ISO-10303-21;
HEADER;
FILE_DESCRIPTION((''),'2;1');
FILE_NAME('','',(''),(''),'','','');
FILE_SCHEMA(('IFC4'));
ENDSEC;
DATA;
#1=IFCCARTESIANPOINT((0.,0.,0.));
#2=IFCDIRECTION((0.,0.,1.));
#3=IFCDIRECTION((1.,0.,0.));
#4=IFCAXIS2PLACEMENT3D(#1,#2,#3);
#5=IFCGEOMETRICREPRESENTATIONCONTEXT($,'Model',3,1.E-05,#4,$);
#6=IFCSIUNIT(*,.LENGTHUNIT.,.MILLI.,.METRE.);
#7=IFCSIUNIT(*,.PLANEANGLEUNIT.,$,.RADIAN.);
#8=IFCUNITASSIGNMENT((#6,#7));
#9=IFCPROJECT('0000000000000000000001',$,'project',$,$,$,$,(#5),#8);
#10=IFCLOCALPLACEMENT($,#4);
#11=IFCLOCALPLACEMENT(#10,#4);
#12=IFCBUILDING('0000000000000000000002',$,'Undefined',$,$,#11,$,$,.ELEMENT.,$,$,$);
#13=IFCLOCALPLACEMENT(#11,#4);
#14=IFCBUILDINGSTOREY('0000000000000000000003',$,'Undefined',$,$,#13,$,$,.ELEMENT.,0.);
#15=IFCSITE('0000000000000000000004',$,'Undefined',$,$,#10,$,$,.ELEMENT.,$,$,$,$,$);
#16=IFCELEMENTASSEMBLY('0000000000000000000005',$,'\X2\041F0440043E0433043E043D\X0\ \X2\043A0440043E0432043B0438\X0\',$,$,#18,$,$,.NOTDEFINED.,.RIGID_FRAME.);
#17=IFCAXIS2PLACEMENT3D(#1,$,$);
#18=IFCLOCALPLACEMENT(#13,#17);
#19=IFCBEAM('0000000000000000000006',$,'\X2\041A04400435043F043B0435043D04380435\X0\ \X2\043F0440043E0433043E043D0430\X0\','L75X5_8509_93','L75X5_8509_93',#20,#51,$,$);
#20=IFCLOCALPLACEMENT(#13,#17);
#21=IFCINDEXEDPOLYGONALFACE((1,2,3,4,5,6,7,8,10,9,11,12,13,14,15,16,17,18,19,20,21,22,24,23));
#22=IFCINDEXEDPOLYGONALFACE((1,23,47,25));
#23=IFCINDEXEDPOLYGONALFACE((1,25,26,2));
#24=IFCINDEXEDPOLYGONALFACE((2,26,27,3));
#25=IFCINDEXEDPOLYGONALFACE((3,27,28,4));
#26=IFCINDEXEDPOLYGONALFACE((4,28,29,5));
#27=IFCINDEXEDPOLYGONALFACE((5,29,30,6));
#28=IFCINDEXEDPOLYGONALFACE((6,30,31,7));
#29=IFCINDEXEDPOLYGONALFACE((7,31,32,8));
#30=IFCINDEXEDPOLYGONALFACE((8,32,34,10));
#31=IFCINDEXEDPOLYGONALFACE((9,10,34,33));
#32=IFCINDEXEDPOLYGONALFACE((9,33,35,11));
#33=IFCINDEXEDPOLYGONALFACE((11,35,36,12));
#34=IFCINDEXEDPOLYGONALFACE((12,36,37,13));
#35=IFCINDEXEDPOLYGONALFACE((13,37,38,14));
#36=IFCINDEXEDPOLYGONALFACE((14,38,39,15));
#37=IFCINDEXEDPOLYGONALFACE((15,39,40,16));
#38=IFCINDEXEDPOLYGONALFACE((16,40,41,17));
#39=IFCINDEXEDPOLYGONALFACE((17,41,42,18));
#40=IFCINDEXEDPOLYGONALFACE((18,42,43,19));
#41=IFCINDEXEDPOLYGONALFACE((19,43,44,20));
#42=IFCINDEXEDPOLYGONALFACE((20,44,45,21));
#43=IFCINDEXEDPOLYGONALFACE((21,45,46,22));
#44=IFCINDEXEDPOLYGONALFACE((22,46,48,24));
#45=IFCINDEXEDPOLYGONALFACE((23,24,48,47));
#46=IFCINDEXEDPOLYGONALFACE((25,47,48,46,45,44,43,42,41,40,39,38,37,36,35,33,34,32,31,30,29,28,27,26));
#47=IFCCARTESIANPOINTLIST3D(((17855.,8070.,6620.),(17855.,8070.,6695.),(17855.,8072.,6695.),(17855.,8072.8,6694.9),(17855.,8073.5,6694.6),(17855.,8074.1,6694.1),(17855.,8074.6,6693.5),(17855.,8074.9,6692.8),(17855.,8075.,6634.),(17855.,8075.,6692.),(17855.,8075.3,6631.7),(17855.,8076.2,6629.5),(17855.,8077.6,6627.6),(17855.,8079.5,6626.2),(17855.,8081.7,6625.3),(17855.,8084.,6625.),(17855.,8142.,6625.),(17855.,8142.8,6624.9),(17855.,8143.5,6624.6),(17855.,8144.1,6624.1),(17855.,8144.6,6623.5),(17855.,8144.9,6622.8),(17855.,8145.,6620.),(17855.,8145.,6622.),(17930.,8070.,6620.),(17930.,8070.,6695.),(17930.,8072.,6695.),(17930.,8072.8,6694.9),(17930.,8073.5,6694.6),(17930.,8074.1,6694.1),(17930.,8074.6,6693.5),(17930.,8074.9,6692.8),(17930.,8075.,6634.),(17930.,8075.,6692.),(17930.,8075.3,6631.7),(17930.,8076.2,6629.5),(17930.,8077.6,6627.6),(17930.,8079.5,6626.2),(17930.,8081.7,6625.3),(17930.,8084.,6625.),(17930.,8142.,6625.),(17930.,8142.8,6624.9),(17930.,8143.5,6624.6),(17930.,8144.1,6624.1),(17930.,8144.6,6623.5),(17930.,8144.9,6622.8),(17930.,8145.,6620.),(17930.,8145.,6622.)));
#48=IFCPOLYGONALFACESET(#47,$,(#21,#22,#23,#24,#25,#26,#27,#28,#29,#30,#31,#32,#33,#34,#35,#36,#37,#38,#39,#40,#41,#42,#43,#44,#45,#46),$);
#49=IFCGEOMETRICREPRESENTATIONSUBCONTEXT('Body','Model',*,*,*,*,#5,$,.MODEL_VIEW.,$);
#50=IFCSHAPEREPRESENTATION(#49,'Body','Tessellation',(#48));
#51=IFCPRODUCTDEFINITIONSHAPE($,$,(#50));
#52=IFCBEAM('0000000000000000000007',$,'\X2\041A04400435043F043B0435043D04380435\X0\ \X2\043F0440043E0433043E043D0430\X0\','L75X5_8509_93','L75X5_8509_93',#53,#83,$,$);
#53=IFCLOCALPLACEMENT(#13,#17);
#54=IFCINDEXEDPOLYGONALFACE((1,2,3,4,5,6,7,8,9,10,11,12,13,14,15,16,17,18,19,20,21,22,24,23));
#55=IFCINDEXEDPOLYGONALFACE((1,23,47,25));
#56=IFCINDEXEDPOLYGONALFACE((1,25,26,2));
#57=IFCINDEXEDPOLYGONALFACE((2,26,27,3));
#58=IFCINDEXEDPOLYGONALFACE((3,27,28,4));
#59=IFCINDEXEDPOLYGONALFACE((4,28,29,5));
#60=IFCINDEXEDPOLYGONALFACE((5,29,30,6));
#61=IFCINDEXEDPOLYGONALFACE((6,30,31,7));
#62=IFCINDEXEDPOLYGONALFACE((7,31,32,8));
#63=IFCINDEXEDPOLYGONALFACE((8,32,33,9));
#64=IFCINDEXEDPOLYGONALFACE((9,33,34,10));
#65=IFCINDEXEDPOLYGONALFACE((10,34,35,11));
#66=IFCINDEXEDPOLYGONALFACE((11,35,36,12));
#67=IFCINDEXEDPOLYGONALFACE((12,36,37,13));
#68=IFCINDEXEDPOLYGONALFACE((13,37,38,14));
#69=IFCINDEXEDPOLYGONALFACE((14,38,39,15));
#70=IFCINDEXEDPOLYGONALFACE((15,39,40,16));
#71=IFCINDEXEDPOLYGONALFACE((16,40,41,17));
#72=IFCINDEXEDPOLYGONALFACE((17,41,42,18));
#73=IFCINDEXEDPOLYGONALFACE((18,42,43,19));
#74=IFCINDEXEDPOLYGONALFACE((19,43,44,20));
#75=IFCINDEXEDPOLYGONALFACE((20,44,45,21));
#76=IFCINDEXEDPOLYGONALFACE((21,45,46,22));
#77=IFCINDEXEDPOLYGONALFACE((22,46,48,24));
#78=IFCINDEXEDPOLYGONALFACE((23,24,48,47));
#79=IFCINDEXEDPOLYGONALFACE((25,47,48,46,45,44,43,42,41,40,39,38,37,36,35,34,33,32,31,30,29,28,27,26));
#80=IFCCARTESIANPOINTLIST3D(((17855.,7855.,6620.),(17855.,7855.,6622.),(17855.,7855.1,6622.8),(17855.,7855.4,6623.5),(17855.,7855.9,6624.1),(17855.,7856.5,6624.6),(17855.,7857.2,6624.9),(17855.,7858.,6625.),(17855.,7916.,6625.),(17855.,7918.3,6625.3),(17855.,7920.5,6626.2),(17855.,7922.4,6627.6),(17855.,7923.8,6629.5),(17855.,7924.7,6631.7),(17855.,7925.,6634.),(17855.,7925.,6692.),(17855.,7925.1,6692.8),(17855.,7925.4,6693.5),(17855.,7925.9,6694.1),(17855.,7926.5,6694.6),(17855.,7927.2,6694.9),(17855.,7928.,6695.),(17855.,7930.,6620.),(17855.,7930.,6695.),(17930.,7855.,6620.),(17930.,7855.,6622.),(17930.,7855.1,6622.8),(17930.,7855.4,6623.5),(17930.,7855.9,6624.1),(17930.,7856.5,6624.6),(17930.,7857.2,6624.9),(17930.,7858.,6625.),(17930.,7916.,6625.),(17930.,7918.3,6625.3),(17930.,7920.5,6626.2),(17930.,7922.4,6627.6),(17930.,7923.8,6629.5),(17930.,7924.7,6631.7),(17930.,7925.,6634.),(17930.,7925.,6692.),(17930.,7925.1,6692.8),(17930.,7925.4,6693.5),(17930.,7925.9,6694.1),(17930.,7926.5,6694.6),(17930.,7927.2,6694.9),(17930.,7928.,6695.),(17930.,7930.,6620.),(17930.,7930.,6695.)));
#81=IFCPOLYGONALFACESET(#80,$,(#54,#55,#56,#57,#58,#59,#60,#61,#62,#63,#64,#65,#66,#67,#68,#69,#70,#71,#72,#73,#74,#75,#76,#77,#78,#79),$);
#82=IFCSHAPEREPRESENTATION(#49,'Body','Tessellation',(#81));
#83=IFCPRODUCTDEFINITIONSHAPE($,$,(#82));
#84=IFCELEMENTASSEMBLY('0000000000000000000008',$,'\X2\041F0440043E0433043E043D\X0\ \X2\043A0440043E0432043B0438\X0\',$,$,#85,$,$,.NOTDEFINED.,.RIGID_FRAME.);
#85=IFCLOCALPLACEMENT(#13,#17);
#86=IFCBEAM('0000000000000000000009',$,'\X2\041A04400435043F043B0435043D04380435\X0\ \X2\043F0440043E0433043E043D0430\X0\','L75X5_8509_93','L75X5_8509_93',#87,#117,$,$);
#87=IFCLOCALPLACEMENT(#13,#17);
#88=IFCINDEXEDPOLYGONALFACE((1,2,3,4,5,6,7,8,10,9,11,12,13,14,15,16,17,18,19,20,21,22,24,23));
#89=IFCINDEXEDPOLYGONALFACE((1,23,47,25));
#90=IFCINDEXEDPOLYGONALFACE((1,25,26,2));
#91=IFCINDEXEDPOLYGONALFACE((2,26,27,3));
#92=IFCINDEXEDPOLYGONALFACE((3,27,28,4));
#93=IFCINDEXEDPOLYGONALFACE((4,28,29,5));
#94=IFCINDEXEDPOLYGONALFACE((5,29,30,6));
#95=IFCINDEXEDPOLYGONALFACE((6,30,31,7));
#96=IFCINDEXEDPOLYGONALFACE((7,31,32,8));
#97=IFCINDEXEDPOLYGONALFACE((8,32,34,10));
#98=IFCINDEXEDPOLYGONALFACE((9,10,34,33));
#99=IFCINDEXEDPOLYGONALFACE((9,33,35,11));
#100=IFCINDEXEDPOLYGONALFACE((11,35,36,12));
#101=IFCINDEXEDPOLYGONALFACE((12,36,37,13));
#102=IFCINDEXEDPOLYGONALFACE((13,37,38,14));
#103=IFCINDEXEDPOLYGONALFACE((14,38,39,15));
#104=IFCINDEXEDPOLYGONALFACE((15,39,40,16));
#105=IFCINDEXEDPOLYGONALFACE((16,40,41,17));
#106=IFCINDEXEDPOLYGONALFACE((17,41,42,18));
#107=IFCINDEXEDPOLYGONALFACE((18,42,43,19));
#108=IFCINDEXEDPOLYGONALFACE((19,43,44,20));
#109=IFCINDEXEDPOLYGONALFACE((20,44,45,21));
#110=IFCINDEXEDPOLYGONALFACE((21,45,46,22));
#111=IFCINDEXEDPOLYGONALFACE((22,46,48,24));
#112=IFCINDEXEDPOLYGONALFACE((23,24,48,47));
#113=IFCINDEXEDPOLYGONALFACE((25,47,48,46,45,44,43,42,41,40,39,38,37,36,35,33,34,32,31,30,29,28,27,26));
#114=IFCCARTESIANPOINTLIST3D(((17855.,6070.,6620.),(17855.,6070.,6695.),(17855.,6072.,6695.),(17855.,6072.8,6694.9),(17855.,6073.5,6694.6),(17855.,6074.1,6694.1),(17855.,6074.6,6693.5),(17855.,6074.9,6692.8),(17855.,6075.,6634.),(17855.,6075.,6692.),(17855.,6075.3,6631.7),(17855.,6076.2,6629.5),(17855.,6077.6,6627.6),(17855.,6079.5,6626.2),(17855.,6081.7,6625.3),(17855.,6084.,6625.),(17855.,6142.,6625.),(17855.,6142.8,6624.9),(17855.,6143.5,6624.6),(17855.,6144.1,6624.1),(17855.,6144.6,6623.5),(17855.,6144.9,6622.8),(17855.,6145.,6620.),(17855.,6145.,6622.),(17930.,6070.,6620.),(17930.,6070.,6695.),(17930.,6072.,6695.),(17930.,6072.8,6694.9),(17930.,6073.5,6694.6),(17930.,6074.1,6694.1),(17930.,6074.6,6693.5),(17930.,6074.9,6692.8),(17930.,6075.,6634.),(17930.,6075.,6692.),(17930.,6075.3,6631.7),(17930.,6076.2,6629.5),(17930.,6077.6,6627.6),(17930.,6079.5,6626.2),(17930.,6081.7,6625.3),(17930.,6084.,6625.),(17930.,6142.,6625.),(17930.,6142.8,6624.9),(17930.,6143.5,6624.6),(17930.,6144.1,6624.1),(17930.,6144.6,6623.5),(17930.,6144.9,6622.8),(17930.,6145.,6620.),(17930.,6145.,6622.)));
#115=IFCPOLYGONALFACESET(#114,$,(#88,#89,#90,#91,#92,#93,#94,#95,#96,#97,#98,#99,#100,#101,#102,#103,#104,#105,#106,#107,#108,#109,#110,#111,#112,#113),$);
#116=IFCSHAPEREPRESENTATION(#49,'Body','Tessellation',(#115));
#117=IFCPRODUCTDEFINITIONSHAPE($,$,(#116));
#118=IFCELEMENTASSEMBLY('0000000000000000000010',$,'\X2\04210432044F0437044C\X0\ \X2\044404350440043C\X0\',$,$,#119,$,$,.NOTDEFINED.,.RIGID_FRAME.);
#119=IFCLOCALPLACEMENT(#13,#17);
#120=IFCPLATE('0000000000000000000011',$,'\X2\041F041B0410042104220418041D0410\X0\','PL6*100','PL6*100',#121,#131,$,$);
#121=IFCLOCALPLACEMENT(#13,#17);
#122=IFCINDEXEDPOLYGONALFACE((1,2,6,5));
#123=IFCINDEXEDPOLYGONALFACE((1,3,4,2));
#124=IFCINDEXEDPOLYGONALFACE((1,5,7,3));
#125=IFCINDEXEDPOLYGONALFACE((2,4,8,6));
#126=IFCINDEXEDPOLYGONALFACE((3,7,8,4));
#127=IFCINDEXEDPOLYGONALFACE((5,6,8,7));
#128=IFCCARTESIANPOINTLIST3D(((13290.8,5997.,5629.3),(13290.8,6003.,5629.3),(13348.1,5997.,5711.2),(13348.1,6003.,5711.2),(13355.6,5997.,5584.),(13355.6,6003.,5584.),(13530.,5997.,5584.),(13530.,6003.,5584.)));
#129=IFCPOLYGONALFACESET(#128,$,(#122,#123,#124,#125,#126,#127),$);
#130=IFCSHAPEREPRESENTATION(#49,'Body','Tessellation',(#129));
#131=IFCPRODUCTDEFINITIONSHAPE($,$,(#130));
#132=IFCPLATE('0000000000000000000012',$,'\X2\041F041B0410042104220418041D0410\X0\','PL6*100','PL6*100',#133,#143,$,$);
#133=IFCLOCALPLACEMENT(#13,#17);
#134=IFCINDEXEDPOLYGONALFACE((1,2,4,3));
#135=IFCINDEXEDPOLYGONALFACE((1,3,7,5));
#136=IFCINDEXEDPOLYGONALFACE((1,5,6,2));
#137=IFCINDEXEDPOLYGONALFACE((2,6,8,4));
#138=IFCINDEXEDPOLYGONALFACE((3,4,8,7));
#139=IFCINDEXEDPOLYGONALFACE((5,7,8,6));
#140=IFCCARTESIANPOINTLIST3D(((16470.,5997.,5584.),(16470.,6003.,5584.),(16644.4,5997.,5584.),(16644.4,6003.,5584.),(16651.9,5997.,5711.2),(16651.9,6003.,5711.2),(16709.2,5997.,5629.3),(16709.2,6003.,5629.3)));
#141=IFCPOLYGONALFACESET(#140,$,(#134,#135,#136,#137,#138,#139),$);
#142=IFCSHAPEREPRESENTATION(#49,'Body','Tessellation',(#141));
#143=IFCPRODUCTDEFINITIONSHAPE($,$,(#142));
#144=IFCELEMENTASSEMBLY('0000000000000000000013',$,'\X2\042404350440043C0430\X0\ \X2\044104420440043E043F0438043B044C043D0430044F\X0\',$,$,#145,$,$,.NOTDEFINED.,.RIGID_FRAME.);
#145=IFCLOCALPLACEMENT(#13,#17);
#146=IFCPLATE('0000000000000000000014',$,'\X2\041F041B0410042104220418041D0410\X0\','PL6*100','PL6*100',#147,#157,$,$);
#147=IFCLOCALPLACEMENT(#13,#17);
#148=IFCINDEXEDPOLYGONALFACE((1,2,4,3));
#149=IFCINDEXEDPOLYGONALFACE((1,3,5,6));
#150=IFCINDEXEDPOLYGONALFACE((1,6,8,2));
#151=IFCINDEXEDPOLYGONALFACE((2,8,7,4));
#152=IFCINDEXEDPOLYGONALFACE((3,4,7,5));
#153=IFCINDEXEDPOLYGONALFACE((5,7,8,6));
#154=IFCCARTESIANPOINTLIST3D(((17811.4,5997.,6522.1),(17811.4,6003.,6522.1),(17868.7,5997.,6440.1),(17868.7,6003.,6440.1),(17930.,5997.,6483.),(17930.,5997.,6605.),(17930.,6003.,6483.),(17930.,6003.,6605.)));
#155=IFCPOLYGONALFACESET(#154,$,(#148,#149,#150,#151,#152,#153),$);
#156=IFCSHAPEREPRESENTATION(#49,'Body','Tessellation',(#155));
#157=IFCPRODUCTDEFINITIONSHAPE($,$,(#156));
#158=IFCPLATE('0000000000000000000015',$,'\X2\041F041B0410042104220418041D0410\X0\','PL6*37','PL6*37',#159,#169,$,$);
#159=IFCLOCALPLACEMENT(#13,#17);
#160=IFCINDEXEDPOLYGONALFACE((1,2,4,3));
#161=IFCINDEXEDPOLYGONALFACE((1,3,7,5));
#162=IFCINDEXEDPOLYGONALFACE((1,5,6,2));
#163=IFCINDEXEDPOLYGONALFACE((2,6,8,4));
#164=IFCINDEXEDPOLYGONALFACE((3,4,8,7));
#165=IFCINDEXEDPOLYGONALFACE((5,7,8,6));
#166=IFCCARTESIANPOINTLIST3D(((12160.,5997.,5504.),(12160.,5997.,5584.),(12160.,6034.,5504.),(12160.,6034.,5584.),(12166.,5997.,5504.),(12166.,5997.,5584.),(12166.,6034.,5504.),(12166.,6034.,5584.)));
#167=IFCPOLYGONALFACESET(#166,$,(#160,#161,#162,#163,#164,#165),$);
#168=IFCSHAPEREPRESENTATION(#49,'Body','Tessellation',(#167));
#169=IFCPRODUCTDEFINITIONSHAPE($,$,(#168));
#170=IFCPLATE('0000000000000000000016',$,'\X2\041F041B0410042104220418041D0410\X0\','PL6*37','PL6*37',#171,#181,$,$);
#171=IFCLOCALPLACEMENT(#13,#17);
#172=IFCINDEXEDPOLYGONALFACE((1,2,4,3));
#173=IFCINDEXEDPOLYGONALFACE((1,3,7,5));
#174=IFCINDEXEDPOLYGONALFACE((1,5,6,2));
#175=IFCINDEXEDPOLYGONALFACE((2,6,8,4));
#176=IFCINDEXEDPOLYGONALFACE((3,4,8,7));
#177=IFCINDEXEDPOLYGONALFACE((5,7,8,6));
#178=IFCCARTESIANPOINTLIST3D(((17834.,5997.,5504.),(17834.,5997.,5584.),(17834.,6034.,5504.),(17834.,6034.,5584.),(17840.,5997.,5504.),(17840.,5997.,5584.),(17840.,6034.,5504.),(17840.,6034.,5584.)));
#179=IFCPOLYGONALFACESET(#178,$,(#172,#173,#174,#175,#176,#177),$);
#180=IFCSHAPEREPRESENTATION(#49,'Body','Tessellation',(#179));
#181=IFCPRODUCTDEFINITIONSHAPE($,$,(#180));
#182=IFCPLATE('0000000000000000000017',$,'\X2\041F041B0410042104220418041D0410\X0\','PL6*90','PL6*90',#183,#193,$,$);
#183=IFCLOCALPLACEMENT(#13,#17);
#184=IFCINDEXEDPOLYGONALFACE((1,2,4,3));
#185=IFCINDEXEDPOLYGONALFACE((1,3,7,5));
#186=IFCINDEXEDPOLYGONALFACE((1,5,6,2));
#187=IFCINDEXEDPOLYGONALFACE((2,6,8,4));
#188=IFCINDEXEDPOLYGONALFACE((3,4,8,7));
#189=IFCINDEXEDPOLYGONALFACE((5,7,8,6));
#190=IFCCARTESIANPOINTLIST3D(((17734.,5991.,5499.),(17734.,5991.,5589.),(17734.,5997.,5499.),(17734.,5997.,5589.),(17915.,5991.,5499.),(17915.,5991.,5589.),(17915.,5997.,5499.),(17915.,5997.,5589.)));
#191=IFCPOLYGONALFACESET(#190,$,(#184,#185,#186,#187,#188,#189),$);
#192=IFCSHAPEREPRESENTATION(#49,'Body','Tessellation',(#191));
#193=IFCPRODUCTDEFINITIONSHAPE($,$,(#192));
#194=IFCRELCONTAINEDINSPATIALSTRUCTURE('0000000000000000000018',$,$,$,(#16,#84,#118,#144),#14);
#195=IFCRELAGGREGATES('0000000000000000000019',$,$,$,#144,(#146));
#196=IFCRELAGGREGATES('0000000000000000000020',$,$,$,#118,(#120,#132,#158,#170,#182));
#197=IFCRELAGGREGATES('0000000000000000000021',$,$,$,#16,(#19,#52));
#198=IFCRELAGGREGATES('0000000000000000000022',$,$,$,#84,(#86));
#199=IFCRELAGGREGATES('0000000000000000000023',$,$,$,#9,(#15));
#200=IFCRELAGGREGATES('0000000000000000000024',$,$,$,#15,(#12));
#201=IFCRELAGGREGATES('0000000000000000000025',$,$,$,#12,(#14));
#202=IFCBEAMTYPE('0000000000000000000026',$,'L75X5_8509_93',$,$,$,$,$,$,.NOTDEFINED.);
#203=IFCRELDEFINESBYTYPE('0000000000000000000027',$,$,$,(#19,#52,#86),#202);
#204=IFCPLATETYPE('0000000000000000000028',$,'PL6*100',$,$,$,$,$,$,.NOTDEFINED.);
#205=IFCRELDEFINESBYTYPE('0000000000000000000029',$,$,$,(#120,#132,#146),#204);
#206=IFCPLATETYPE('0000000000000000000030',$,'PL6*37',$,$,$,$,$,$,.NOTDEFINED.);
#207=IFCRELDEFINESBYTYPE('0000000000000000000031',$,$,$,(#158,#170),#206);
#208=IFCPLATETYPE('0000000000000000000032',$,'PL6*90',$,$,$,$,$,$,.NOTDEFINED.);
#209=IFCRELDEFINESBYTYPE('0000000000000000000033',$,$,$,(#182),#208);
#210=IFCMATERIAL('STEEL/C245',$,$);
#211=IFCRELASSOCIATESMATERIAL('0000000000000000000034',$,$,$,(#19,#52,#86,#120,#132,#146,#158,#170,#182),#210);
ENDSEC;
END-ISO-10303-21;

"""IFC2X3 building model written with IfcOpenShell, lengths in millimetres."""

from ifc_helpers import new_model, si_unit, frame, origin_with_axes, origin_2d_with_axis, place, context, subcontext, project, spatial, polyline, l_section, outline, extrude, material, type_object, element, aggregate, save


model = new_model("IFC2X3")

# Units and contexts
model_context = context("Model", 3, precision=1e-05, world=origin_with_axes())
body_context = subcontext(model_context, "Body", "Model", "MODEL_VIEW")
ifc_project = project(units=[si_unit("LENGTHUNIT", "METRE", prefix="MILLI"), si_unit("PLANEANGLEUNIT", "RADIAN")], contexts=[model_context])

# Site, building, storey
site_placement = place(None, origin_with_axes())
site = spatial("IfcSite", under=ifc_project, at=site_placement, Name="Undefined", CompositionType="ELEMENT")
building_placement = place(site_placement, origin_with_axes())
building = spatial("IfcBuilding", under=site, at=building_placement, Name="Undefined", CompositionType="ELEMENT")
storey_placement = place(building_placement, origin_with_axes())
storey = spatial("IfcBuildingStorey", under=building, at=storey_placement, Name="Undefined", CompositionType="ELEMENT", Elevation=0.0)

# Shared definitions
ifc_material_1 = material(Name="STEEL/C245")

# Element assembly, beams
beam_type = type_object("IfcBeamType", Name="L75X5_8509_93", PredefinedType="NOTDEFINED")
assembly_1_placement = place(storey_placement, origin_with_axes())
assembly_1 = element("IfcElementAssembly", 1, at=assembly_1_placement, inside=storey, Name="Прогон кровли", AssemblyPlace="NOTDEFINED", PredefinedType="RIGID_FRAME")
beam_1_placement = place(assembly_1_placement, frame((17855.0, 8107.5, 6657.5), z_axis=(0.0, 1.0, 0.0), x_axis=(1.0, 0.0, 0.0)))
beam_1 = element("IfcBeam", 2, at=beam_1_placement, type_object=beam_type, material=ifc_material_1, Name="Крепление прогона", Description="L75X5_8509_93", ObjectType="L75X5_8509_93", context=body_context, shape_type="SweptSolid", body=[
    extrude(l_section(Depth=75.0, Width=75.0, Thickness=5.0, FilletRadius=9.0, EdgeRadius=3.0, at=origin_2d_with_axis()), frame((75.0, 0.0, 0.0), z_axis=(-1.0, 0.0, 0.0), x_axis=(0.0, -1.0, 0.0)), (0.0, 0.0, 1.0), 75.0),
])
beam_2_placement = place(assembly_1_placement, frame((17930.0, 7892.5, 6657.5), z_axis=(0.0, -1.0, 0.0), x_axis=(-1.0, 0.0, 0.0)))
beam_2 = element("IfcBeam", 3, at=beam_2_placement, type_object=beam_type, material=ifc_material_1, Name="Крепление прогона", Description="L75X5_8509_93", ObjectType="L75X5_8509_93", context=body_context, shape_type="SweptSolid", body=[
    extrude(l_section(Depth=75.0, Width=75.0, Thickness=5.0, FilletRadius=9.0, EdgeRadius=3.0, at=origin_2d_with_axis()), frame((75.0, 0.0, 0.0), z_axis=(-1.0, 0.0, 0.0), x_axis=(0.0, -1.0, 0.0)), (0.0, 0.0, 1.0), 75.0),
])

# Element assembly, beam
assembly_2_placement = place(storey_placement, origin_with_axes())
assembly_2 = element("IfcElementAssembly", 4, at=assembly_2_placement, inside=storey, Name="Прогон кровли", AssemblyPlace="NOTDEFINED", PredefinedType="RIGID_FRAME")
beam_3_placement = place(assembly_2_placement, frame((17855.0, 6107.5, 6657.5), z_axis=(0.0, 1.0, 0.0), x_axis=(1.0, 0.0, 0.0)))
beam_3 = element("IfcBeam", 5, at=beam_3_placement, type_object=beam_type, material=ifc_material_1, Name="Крепление прогона", Description="L75X5_8509_93", ObjectType="L75X5_8509_93", context=body_context, shape_type="SweptSolid", body=[
    extrude(l_section(Depth=75.0, Width=75.0, Thickness=5.0, FilletRadius=9.0, EdgeRadius=3.0, at=origin_2d_with_axis()), frame((75.0, 0.0, 0.0), z_axis=(-1.0, 0.0, 0.0), x_axis=(0.0, -1.0, 0.0)), (0.0, 0.0, 1.0), 75.0),
])

# Element assembly, plates
assembly_3_placement = place(storey_placement, origin_with_axes())
assembly_3 = element("IfcElementAssembly", 6, at=assembly_3_placement, inside=storey, Name="Связь ферм", AssemblyPlace="NOTDEFINED", PredefinedType="RIGID_FRAME")
plate_type_1 = type_object("IfcPlateType", Name="PL6*100", PredefinedType="NOTDEFINED")
plate_1_placement = place(assembly_3_placement, frame((13530.0, 6000.0, 5584.0), z_axis=(0.0, -1.0, 0.0), x_axis=(-0.819501, 0.0, 0.573078)))
plate_1 = element("IfcPlate", 7, at=plate_1_placement, type_object=plate_type_1, material=ifc_material_1, Name="ПЛАСТИНА", Description="PL6*100", ObjectType="PL6*100", context=body_context, shape_type="SweptSolid", body=[
    extrude(outline(polyline([(0.0, 0.0), (222.0, 0.0), (222.0, 100.0), (143.0, 100.0), (0.0, 0.0)])), frame((0.0, 0.0, -3.0), z_axis=(0.0, 0.0, 1.0), x_axis=(1.0, 0.0, 0.0)), (0.0, 0.0, 1.0), 6.0),
])
plate_2_placement = place(assembly_3_placement, frame((16470.0, 6000.0, 5584.0), z_axis=(0.0, 1.0, 0.0), x_axis=(0.819501, 0.0, 0.573078)))
plate_2 = element("IfcPlate", 8, at=plate_2_placement, type_object=plate_type_1, material=ifc_material_1, Name="ПЛАСТИНА", Description="PL6*100", ObjectType="PL6*100", context=body_context, shape_type="SweptSolid", body=[
    extrude(outline(polyline([(0.0, 0.0), (222.0, 0.0), (222.0, 100.0), (143.0, 100.0), (0.0, 0.0)])), frame((0.0, 0.0, -3.0), z_axis=(0.0, 0.0, 1.0), x_axis=(1.0, 0.0, 0.0)), (0.0, 0.0, 1.0), 6.0),
])

# Element assembly, plate
assembly_4_placement = place(storey_placement, origin_with_axes())
assembly_4 = element("IfcElementAssembly", 9, at=assembly_4_placement, inside=storey, Name="Ферма стропильная", AssemblyPlace="NOTDEFINED", PredefinedType="RIGID_FRAME")
plate_3_placement = place(assembly_4_placement, frame((17930.0, 6000.0, 6483.0), z_axis=(0.0, 1.0, 0.0), x_axis=(-0.819501, 0.0, -0.573078)))
plate_3 = element("IfcPlate", 10, at=plate_3_placement, type_object=plate_type_1, material=ifc_material_1, Name="ПЛАСТИНА", Description="PL6*100", ObjectType="PL6*100", context=body_context, shape_type="SweptSolid", body=[
    extrude(outline(polyline([(0.0, 0.0), (74.8, 0.0), (74.8, 100.0), (-69.9, 100.0), (0.0, 0.0)])), frame((0.0, 0.0, -3.0), z_axis=(0.0, 0.0, 1.0), x_axis=(1.0, 0.0, 0.0)), (0.0, 0.0, 1.0), 6.0),
])

# Plates
plate_type_2 = type_object("IfcPlateType", Name="PL6*37", PredefinedType="NOTDEFINED")
plate_4_placement = place(assembly_3_placement, frame((12163.0, 6015.5, 5504.0), z_axis=(1.0, 0.0, 0.0), x_axis=(0.0, 0.0, 1.0)))
plate_4 = element("IfcPlate", 11, at=plate_4_placement, type_object=plate_type_2, material=ifc_material_1, Name="ПЛАСТИНА", Description="PL6*37", ObjectType="PL6*37", context=body_context, shape_type="SweptSolid", body=[
    extrude(outline(polyline([(0.0, 18.5), (80.0, 18.5), (80.0, -18.5), (0.0, -18.5), (0.0, 18.5)])), frame((0.0, 0.0, -3.0), z_axis=(0.0, 0.0, 1.0), x_axis=(1.0, 0.0, 0.0)), (0.0, 0.0, 1.0), 6.0),
])
plate_5_placement = place(assembly_3_placement, frame((17837.0, 6015.5, 5584.0), z_axis=(-1.0, 0.0, 0.0), x_axis=(0.0, 0.0, -1.0)))
plate_5 = element("IfcPlate", 12, at=plate_5_placement, type_object=plate_type_2, material=ifc_material_1, Name="ПЛАСТИНА", Description="PL6*37", ObjectType="PL6*37", context=body_context, shape_type="SweptSolid", body=[
    extrude(outline(polyline([(80.0, 18.5), (80.0, -18.5), (0.0, -18.5), (0.0, 18.5), (80.0, 18.5)])), frame((0.0, 0.0, -3.0), z_axis=(0.0, 0.0, 1.0), x_axis=(1.0, 0.0, 0.0)), (0.0, 0.0, 1.0), 6.0),
])
plate_type_3 = type_object("IfcPlateType", Name="PL6*90", PredefinedType="NOTDEFINED")
plate_6_placement = place(assembly_3_placement, frame((17915.0, 5994.0, 5544.0), z_axis=(0.0, 1.0, 0.0), x_axis=(-1.0, 0.0, 0.0)))
plate_6 = element("IfcPlate", 13, at=plate_6_placement, type_object=plate_type_3, material=ifc_material_1, Name="ПЛАСТИНА", Description="PL6*90", ObjectType="PL6*90", context=body_context, shape_type="SweptSolid", body=[
    extrude(outline(polyline([(181.0, -45.0), (0.0, -45.0), (0.0, 45.0), (181.0, 45.0), (181.0, -45.0)])), frame((0.0, 0.0, -3.0), z_axis=(0.0, 0.0, 1.0), x_axis=(1.0, 0.0, 0.0)), (0.0, 0.0, 1.0), 6.0),
])

aggregate(assembly_4, [plate_3])

aggregate(assembly_3, [plate_1, plate_2, plate_4, plate_5, plate_6])
aggregate(assembly_1, [beam_1, beam_2])
aggregate(assembly_2, [beam_3])

save(model, "model.ifc")
